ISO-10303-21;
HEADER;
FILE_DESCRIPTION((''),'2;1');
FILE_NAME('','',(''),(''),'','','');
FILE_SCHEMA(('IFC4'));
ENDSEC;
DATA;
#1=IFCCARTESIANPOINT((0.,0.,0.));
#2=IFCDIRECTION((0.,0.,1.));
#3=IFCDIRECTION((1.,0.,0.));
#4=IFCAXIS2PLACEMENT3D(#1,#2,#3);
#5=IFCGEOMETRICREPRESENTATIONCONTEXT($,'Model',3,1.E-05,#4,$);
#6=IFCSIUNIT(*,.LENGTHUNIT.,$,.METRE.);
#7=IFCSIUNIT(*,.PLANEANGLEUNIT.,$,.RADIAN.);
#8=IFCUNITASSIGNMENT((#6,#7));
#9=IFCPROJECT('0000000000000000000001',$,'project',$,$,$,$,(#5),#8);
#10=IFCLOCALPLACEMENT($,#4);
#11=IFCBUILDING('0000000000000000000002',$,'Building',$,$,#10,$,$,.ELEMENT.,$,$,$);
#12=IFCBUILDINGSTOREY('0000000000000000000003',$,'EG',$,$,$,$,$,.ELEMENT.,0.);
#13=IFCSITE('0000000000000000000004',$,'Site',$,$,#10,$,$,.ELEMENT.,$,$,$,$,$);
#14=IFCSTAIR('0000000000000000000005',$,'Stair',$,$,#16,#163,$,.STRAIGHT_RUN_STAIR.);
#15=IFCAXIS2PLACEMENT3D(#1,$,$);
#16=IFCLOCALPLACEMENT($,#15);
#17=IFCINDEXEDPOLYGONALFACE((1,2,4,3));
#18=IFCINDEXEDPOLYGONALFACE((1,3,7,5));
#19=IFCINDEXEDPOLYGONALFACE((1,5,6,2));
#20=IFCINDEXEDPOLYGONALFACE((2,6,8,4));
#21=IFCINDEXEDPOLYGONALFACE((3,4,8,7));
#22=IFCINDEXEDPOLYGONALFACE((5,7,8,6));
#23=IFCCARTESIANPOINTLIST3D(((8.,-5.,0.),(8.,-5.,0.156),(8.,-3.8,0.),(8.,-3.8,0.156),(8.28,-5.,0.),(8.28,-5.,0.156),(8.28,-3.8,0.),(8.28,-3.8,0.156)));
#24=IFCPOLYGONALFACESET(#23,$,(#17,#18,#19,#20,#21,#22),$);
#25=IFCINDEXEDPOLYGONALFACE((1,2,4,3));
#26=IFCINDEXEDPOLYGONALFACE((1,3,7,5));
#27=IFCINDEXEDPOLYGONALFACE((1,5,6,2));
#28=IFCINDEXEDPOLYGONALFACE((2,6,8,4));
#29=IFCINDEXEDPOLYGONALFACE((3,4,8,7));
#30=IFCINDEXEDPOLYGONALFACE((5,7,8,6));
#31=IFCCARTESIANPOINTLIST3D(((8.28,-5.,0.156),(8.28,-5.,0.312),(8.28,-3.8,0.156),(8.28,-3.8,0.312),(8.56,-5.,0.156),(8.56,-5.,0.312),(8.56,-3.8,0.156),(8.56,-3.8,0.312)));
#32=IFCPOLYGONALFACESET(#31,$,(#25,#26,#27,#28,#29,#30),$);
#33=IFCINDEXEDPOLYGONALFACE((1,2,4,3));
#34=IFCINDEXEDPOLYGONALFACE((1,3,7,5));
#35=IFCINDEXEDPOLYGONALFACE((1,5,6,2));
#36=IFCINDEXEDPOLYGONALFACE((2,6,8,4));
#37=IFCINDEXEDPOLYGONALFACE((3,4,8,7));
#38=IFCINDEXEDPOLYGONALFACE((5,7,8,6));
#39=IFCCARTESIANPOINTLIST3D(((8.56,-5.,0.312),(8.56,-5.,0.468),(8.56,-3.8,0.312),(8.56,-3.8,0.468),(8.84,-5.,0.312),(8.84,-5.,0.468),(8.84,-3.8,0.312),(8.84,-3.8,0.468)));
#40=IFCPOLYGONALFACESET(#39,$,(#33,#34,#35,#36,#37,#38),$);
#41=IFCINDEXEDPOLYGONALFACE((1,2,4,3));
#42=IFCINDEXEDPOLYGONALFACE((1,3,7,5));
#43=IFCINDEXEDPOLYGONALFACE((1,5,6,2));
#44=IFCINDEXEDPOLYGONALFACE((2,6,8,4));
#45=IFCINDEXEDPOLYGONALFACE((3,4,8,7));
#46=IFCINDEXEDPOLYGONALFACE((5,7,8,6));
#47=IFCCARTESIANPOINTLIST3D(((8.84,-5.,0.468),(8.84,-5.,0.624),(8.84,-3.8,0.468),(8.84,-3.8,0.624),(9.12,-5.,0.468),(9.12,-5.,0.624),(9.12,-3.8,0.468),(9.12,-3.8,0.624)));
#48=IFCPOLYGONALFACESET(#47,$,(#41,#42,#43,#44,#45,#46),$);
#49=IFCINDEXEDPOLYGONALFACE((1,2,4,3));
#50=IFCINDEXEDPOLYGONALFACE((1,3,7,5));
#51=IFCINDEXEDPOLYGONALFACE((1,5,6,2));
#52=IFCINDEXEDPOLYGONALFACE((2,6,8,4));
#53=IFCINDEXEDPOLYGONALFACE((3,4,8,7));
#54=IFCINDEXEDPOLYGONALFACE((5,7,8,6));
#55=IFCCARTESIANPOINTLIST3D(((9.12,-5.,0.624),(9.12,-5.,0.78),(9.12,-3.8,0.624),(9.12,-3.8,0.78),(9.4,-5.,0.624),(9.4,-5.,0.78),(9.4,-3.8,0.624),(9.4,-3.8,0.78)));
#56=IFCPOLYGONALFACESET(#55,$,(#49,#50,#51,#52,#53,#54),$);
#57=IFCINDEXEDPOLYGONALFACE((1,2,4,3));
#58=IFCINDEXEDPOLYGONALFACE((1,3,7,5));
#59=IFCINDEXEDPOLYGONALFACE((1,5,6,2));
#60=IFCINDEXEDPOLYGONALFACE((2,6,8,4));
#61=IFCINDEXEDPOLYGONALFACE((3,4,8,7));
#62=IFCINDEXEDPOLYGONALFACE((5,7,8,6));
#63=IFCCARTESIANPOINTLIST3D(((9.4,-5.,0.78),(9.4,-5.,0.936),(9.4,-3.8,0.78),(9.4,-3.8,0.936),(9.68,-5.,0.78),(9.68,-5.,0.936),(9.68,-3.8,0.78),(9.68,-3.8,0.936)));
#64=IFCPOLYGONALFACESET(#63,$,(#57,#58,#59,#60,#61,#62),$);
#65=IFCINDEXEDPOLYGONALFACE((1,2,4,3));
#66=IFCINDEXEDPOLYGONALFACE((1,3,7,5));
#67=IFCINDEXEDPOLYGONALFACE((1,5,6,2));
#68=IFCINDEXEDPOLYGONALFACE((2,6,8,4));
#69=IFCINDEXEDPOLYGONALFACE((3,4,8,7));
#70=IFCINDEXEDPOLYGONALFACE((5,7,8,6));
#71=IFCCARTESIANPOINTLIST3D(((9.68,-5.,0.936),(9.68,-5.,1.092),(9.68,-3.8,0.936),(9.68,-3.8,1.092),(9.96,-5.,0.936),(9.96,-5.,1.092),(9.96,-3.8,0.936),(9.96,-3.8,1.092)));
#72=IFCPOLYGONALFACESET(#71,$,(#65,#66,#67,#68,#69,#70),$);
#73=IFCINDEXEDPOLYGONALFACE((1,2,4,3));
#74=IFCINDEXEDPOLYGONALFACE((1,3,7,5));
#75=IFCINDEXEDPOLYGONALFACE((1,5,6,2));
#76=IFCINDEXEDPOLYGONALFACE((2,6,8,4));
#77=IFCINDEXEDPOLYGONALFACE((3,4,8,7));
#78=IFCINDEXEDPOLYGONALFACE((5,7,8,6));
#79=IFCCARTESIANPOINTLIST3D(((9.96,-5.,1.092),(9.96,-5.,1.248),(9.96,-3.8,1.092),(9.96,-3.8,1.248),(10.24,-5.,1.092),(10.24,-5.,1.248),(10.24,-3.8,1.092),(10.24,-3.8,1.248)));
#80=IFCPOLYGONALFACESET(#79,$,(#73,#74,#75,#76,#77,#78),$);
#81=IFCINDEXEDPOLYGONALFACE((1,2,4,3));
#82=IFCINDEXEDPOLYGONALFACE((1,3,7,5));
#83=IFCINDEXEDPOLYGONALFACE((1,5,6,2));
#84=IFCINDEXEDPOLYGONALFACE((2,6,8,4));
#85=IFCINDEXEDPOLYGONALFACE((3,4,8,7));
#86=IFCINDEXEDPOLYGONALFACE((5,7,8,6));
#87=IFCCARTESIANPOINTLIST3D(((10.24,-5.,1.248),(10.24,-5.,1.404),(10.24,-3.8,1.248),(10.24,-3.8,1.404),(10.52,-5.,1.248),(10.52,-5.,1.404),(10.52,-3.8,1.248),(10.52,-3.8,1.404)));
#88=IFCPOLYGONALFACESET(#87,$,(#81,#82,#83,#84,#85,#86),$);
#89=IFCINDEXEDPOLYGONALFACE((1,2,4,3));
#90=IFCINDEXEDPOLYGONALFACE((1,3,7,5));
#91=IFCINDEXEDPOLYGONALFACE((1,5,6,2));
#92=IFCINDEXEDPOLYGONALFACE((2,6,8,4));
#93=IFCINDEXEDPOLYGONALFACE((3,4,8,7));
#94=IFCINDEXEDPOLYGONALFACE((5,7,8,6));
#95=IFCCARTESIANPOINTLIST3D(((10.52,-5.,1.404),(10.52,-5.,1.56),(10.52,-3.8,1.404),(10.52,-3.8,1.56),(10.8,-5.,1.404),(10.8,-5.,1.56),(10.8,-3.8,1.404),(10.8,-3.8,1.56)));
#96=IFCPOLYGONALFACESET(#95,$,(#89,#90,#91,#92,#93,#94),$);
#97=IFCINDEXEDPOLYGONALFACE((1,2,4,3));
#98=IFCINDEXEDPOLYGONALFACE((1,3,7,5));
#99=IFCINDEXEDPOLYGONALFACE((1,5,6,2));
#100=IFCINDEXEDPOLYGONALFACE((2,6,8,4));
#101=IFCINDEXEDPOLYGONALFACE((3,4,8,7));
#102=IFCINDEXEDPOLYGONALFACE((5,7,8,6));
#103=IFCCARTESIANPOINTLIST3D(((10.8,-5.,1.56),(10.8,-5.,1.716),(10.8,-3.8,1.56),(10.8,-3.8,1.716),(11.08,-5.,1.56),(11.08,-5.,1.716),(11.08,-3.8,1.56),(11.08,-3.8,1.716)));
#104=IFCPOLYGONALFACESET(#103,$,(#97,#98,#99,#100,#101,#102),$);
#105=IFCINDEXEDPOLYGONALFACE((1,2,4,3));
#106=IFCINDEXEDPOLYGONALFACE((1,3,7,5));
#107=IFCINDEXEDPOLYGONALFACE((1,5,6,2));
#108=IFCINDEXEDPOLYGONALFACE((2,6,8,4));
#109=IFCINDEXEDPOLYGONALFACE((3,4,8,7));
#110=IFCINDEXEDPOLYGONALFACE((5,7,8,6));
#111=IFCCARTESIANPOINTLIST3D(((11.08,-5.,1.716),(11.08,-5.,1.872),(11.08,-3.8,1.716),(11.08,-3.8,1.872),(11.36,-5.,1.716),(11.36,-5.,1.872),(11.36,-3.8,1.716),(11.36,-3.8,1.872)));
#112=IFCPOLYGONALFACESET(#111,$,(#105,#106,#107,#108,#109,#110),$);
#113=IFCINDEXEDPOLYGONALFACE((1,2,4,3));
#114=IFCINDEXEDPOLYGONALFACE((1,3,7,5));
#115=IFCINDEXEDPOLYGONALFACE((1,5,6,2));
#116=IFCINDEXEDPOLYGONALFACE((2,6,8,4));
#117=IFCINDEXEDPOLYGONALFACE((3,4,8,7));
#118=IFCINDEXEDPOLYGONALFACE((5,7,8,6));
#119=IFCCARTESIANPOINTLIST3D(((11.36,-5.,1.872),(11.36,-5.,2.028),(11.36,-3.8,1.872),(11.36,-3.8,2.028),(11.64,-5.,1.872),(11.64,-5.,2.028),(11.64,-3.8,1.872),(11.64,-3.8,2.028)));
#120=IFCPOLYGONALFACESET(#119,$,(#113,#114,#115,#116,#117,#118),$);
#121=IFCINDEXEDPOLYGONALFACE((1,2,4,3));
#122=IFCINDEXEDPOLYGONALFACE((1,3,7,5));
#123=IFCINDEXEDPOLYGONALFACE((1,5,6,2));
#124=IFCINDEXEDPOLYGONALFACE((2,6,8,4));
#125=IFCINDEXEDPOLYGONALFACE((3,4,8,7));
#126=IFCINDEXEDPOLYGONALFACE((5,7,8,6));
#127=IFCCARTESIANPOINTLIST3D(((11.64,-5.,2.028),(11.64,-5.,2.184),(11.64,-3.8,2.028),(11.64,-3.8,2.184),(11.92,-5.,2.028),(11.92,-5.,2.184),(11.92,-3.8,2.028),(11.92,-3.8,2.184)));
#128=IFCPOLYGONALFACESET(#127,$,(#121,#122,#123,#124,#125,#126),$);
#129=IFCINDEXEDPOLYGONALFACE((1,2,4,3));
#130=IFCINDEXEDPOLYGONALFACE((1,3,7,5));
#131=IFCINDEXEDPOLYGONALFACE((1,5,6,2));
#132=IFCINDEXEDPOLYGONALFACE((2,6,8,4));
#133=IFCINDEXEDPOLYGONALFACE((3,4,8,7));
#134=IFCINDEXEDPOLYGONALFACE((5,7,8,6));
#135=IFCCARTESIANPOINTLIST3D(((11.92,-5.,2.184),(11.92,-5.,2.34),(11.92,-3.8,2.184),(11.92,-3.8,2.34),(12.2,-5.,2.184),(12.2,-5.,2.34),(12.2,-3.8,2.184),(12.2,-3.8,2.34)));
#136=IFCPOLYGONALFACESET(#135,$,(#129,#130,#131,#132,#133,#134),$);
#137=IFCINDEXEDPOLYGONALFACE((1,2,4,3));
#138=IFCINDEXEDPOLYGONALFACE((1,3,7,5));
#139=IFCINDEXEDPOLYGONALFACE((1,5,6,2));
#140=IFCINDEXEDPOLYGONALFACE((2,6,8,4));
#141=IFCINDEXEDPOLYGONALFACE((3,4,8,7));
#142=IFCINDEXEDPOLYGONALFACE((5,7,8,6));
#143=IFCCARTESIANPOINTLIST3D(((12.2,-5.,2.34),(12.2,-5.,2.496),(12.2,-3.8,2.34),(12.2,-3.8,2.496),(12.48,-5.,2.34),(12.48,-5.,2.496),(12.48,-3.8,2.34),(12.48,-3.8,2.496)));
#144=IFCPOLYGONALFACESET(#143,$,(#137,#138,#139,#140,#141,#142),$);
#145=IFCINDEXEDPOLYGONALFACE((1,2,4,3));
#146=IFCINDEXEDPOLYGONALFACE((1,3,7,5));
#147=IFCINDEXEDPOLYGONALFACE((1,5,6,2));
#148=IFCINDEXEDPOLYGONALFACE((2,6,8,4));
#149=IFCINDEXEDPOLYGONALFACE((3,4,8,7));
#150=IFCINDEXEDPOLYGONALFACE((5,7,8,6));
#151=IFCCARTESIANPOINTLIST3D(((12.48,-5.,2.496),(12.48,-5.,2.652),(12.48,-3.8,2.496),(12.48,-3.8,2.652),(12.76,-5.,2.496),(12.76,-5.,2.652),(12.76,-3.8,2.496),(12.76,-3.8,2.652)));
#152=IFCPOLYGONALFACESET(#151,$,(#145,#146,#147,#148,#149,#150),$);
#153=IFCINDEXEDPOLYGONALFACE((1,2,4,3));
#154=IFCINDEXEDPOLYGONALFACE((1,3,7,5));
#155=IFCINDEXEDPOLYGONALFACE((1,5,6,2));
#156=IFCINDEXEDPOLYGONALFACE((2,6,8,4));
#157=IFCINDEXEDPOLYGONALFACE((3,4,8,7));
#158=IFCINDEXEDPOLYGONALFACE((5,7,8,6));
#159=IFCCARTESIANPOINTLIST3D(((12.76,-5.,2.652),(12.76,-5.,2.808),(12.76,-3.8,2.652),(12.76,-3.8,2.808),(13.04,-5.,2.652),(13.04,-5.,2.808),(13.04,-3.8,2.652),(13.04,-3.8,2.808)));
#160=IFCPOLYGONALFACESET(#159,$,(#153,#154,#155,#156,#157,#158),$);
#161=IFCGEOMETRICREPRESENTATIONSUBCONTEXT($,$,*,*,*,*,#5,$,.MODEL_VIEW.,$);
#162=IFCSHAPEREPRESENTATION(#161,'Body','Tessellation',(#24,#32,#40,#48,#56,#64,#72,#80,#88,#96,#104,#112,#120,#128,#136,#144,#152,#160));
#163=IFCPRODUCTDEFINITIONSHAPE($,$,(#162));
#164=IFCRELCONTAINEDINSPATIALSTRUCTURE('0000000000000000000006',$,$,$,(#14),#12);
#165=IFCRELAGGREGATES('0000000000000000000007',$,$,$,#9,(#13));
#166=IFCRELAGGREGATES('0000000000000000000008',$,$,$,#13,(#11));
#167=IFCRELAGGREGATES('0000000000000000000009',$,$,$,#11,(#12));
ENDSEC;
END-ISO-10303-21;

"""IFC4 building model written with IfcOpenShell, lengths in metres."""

from ifc_helpers import new_model, si_unit, frame, frame_2d, origin, origin_with_axes, place, context, subcontext, project, spatial, rectangle, extrude, element, save


model = new_model("IFC4")

# Units and contexts
model_context = context("Model", 3, precision=1e-05, world=origin_with_axes())
sub_context = subcontext(model_context, None, None, "MODEL_VIEW")
ifc_project = project(units=[si_unit("LENGTHUNIT", "METRE"), si_unit("PLANEANGLEUNIT", "RADIAN")], contexts=[model_context])

# Site, building, storey
placement_1 = place(None, origin_with_axes())
site = spatial("IfcSite", under=ifc_project, at=placement_1, Name="Site", CompositionType="ELEMENT")
building = spatial("IfcBuilding", under=site, at=placement_1, Name="Building", CompositionType="ELEMENT")
storey = spatial("IfcBuildingStorey", under=building, Name="EG", CompositionType="ELEMENT", Elevation=0.0)

# Stair
placement_2 = place(None, origin_with_axes())
placement_3 = place(placement_2, origin())
stair_placement = place(placement_3, frame((8.0, -5.0, 0.0)))
element("IfcStair", 1, at=stair_placement, inside=storey, Name="Stair", PredefinedType="STRAIGHT_RUN_STAIR", context=sub_context, shape_type="SolidModel", body=[
    extrude(rectangle(XDim=0.28, YDim=1.2, at=frame_2d((0.14, 0.6))), origin(), (0.0, 0.0, 1.0), 0.156),
    extrude(rectangle(XDim=0.28, YDim=1.2, at=frame_2d((0.14, 0.6))), frame((0.28, 0.0, 0.156)), (0.0, 0.0, 1.0), 0.156),
    extrude(rectangle(XDim=0.28, YDim=1.2, at=frame_2d((0.14, 0.6))), frame((0.56, 0.0, 0.312)), (0.0, 0.0, 1.0), 0.156),
    extrude(rectangle(XDim=0.28, YDim=1.2, at=frame_2d((0.14, 0.6))), frame((0.84, 0.0, 0.468)), (0.0, 0.0, 1.0), 0.156),
    extrude(rectangle(XDim=0.28, YDim=1.2, at=frame_2d((0.14, 0.6))), frame((1.12, 0.0, 0.624)), (0.0, 0.0, 1.0), 0.156),
    extrude(rectangle(XDim=0.28, YDim=1.2, at=frame_2d((0.14, 0.6))), frame((1.4, 0.0, 0.78)), (0.0, 0.0, 1.0), 0.156),
    extrude(rectangle(XDim=0.28, YDim=1.2, at=frame_2d((0.14, 0.6))), frame((1.68, 0.0, 0.936)), (0.0, 0.0, 1.0), 0.156),
    extrude(rectangle(XDim=0.28, YDim=1.2, at=frame_2d((0.14, 0.6))), frame((1.96, 0.0, 1.092)), (0.0, 0.0, 1.0), 0.156),
    extrude(rectangle(XDim=0.28, YDim=1.2, at=frame_2d((0.14, 0.6))), frame((2.24, 0.0, 1.248)), (0.0, 0.0, 1.0), 0.156),
    extrude(rectangle(XDim=0.28, YDim=1.2, at=frame_2d((0.14, 0.6))), frame((2.52, 0.0, 1.404)), (0.0, 0.0, 1.0), 0.156),
    extrude(rectangle(XDim=0.28, YDim=1.2, at=frame_2d((0.14, 0.6))), frame((2.8, 0.0, 1.56)), (0.0, 0.0, 1.0), 0.156),
    extrude(rectangle(XDim=0.28, YDim=1.2, at=frame_2d((0.14, 0.6))), frame((3.08, 0.0, 1.716)), (0.0, 0.0, 1.0), 0.156),
    extrude(rectangle(XDim=0.28, YDim=1.2, at=frame_2d((0.14, 0.6))), frame((3.36, 0.0, 1.872)), (0.0, 0.0, 1.0), 0.156),
    extrude(rectangle(XDim=0.28, YDim=1.2, at=frame_2d((0.14, 0.6))), frame((3.64, 0.0, 2.028)), (0.0, 0.0, 1.0), 0.156),
    extrude(rectangle(XDim=0.28, YDim=1.2, at=frame_2d((0.14, 0.6))), frame((3.92, 0.0, 2.184)), (0.0, 0.0, 1.0), 0.156),
    extrude(rectangle(XDim=0.28, YDim=1.2, at=frame_2d((0.14, 0.6))), frame((4.2, 0.0, 2.34)), (0.0, 0.0, 1.0), 0.156),
    extrude(rectangle(XDim=0.28, YDim=1.2, at=frame_2d((0.14, 0.6))), frame((4.48, 0.0, 2.496)), (0.0, 0.0, 1.0), 0.156),
    extrude(rectangle(XDim=0.28, YDim=1.2, at=frame_2d((0.14, 0.6))), frame((4.76, 0.0, 2.652)), (0.0, 0.0, 1.0), 0.156),
])

save(model, "model.ifc")
